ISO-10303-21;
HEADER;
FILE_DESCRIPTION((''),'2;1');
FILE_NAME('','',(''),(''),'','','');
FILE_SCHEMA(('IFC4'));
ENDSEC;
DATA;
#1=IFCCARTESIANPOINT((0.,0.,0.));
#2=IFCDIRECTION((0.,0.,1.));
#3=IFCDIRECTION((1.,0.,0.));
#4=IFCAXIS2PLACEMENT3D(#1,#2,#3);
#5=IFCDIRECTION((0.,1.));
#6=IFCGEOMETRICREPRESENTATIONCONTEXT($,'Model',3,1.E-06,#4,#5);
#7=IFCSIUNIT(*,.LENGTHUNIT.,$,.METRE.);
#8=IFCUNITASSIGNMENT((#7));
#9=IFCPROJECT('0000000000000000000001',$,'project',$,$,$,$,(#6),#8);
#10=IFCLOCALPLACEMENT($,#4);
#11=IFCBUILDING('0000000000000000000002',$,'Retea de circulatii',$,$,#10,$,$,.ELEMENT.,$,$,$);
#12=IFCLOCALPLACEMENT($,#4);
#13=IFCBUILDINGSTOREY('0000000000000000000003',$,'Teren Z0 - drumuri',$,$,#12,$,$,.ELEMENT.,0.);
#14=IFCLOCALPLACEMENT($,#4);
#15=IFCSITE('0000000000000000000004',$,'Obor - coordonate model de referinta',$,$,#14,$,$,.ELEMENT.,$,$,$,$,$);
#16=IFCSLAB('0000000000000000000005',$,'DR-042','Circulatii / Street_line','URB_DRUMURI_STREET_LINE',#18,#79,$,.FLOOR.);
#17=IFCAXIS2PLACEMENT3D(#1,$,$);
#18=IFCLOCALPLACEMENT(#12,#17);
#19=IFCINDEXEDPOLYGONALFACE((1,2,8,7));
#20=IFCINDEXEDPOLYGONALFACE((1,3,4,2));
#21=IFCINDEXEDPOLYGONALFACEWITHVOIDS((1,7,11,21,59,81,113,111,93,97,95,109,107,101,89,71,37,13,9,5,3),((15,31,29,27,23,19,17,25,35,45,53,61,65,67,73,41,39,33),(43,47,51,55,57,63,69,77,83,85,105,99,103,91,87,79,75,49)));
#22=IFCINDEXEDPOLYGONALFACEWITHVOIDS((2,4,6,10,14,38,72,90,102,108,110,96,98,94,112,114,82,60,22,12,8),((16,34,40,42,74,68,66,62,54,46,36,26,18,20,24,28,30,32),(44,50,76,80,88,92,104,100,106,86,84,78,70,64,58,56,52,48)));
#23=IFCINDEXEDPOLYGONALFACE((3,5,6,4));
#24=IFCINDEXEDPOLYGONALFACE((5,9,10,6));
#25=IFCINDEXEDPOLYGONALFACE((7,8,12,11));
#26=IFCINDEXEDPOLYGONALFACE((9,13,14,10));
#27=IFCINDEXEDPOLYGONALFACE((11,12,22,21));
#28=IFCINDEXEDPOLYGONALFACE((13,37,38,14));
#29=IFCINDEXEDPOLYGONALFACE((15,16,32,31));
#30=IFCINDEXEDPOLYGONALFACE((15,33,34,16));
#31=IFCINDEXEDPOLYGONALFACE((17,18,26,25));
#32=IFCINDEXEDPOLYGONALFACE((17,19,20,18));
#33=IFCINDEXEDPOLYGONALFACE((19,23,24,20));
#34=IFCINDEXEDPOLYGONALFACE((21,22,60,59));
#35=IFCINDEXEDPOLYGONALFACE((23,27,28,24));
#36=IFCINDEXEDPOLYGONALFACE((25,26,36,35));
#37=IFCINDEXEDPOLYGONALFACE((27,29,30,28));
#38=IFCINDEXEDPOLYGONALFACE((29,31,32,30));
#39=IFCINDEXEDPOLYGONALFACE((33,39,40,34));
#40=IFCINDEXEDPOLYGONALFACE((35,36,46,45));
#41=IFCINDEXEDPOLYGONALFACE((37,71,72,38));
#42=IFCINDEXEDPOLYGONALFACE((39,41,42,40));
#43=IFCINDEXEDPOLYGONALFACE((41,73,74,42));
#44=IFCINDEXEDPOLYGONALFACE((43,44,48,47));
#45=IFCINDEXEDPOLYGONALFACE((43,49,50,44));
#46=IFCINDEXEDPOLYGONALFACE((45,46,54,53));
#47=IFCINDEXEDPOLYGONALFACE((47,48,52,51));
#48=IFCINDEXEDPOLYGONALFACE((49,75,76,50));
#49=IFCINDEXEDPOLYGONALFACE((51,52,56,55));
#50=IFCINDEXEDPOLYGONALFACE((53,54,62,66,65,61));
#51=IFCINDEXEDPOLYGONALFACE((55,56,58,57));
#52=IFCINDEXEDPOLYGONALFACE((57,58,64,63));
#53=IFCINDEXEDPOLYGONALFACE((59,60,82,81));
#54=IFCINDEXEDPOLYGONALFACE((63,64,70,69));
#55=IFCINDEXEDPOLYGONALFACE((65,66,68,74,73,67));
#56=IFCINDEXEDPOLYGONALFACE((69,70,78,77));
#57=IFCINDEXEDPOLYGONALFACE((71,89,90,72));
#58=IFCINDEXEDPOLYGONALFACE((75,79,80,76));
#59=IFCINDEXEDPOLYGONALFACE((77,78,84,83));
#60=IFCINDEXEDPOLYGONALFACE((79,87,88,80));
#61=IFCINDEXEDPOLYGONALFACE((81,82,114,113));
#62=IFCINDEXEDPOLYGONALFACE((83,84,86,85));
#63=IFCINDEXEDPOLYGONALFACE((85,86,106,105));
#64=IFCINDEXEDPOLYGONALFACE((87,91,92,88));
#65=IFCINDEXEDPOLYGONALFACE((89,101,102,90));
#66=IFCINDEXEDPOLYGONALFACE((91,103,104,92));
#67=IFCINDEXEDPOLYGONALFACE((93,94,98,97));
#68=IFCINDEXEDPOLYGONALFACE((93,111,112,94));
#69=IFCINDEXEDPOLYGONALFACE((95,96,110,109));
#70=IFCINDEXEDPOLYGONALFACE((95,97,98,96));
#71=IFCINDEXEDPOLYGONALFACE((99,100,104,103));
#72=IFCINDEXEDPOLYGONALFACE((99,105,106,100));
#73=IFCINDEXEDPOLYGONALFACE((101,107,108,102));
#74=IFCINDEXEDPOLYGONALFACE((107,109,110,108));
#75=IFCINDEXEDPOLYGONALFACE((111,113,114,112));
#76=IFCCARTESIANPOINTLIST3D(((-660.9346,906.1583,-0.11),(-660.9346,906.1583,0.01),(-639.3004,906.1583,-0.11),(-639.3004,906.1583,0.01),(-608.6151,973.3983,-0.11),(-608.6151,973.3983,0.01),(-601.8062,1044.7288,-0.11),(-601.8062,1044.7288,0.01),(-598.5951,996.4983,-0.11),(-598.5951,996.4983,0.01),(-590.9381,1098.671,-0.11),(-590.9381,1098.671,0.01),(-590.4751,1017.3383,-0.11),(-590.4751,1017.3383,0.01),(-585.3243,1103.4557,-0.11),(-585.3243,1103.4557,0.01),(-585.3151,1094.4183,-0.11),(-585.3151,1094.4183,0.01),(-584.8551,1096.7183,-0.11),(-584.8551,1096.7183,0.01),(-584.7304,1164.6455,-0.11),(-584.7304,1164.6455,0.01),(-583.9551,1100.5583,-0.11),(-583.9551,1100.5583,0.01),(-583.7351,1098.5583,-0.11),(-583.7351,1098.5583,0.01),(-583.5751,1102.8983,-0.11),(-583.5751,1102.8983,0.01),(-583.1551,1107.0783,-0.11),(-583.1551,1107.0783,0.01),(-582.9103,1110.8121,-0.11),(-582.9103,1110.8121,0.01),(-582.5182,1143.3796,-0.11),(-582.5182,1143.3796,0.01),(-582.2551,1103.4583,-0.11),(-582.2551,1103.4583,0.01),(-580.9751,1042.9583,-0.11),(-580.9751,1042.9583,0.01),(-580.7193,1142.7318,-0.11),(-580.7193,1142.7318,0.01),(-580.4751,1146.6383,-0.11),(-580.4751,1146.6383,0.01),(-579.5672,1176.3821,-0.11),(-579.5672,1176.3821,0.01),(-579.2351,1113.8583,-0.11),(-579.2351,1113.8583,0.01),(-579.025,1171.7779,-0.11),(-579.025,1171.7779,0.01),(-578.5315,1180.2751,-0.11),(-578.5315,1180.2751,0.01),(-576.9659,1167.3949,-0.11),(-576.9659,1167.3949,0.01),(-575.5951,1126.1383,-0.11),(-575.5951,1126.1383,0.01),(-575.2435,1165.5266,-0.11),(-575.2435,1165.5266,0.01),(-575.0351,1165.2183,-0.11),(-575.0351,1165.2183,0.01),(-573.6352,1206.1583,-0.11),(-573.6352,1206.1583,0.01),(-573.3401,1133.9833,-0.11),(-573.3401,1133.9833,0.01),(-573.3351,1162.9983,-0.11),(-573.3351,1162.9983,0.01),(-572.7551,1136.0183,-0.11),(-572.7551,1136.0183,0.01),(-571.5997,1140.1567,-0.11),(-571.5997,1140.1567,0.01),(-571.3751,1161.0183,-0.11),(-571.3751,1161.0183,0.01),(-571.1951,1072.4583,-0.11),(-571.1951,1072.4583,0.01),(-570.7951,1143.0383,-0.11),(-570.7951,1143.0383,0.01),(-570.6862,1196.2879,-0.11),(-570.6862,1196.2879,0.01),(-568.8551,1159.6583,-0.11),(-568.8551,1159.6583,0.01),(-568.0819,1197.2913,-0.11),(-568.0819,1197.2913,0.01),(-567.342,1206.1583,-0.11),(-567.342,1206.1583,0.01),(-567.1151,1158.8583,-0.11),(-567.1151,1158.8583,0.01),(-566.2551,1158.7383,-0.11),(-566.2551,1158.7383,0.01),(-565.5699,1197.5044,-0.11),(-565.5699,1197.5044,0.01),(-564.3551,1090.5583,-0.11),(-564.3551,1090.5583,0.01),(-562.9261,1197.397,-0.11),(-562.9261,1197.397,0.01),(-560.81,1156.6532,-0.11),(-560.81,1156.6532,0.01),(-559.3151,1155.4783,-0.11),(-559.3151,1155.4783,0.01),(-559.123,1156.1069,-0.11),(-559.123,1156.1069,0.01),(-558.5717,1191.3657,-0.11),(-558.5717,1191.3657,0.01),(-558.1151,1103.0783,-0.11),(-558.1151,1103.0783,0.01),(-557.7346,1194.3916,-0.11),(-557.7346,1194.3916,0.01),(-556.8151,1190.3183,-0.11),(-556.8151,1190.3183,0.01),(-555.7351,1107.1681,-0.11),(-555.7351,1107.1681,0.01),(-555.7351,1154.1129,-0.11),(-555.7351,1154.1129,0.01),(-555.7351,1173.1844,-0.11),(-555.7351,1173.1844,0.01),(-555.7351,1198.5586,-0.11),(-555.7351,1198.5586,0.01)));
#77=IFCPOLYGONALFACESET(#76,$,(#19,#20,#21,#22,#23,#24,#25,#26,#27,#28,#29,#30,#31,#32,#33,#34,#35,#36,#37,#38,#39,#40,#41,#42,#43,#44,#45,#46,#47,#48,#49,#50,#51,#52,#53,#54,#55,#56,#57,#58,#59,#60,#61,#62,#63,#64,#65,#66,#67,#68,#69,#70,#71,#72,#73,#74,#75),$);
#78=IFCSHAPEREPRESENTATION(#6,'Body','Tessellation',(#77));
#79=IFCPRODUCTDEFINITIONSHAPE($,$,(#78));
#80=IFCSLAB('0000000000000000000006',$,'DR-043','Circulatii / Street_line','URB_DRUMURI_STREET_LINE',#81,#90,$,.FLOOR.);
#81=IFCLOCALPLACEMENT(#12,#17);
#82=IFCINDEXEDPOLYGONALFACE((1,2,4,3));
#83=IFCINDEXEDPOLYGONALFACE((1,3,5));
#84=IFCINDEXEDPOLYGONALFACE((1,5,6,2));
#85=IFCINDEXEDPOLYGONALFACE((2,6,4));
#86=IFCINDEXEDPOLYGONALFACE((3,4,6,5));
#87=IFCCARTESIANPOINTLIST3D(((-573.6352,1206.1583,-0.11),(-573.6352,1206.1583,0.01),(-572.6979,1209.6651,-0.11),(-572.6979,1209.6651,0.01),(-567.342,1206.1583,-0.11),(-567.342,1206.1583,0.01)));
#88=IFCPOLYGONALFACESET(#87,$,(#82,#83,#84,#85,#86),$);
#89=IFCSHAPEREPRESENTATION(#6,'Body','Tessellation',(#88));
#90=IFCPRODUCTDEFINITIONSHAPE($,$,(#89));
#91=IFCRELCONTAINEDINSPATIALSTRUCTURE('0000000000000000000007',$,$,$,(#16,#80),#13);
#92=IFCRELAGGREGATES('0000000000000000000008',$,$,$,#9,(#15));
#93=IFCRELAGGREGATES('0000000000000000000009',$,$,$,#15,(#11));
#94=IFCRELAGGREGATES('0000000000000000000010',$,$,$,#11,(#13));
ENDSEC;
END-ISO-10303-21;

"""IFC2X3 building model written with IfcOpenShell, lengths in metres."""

from ifc_helpers import new_model, si_unit, direction, frame, origin_with_axes, place, context, project, spatial, polyline, outline, extrude, element, save


model = new_model("IFC2X3")

# Units and contexts
model_context = context("Model", 3, precision=1e-06, world=origin_with_axes(), true_north=direction((0.0, 1.0)))
ifc_project = project(units=[si_unit("LENGTHUNIT", "METRE")], contexts=[model_context])

# Site, building, storey
site_placement = place(None, origin_with_axes())
site = spatial("IfcSite", under=ifc_project, at=site_placement, Name="Obor - coordonate model de referinta", CompositionType="ELEMENT")
building_placement = place(None, origin_with_axes())
building = spatial("IfcBuilding", under=site, at=building_placement, Name="Retea de circulatii", CompositionType="ELEMENT")
storey_placement = place(None, origin_with_axes())
storey = spatial("IfcBuildingStorey", under=building, at=storey_placement, Name="Teren Z0 - drumuri", CompositionType="ELEMENT", Elevation=0.0)

# Slabs
slab_1_placement = place(None, origin_with_axes())
element("IfcSlab", 1, at=slab_1_placement, inside=storey, Name="DR-042", Description="Circulatii / Street_line", ObjectType="URB_DRUMURI_STREET_LINE", PredefinedType="FLOOR", context=model_context, shape_type="SweptSolid", body=[
    extrude(outline(polyline([(-584.7304, 1164.6455), (-590.9381, 1098.671), (-601.8062, 1044.7288), (-660.9346, 906.1583), (-639.3004, 906.1583), (-608.6151, 973.3983), (-598.5951, 996.4983), (-590.4751, 1017.3383), (-580.9751, 1042.9583), (-571.1951, 1072.4583), (-564.3551, 1090.5583), (-558.1151, 1103.0783), (-555.7351, 1107.1681), (-555.7351, 1154.1129), (-559.3151, 1155.4783), (-559.123, 1156.1069), (-560.81, 1156.6532), (-555.7351, 1173.1844), (-555.7351, 1198.5586), (-567.342, 1206.1583), (-573.6352, 1206.1583), (-584.7304, 1164.6455)]), holes=[polyline([(-571.5997, 1140.1567), (-572.7551, 1136.0183), (-573.3401, 1133.9833), (-575.5951, 1126.1383), (-579.2351, 1113.8583), (-582.2551, 1103.4583), (-583.7351, 1098.5583), (-585.3151, 1094.4183), (-584.8551, 1096.7183), (-583.9551, 1100.5583), (-583.5751, 1102.8983), (-583.1551, 1107.0783), (-582.9103, 1110.8121), (-585.3243, 1103.4557), (-582.5182, 1143.3796), (-580.7193, 1142.7318), (-580.4751, 1146.6383), (-570.7951, 1143.0383), (-571.5997, 1140.1567)]), polyline([(-570.6862, 1196.2879), (-568.0819, 1197.2913), (-565.5699, 1197.5044), (-562.9261, 1197.397), (-557.7346, 1194.3916), (-558.5717, 1191.3657), (-556.8151, 1190.3183), (-566.2551, 1158.7383), (-567.1151, 1158.8583), (-568.8551, 1159.6583), (-571.3751, 1161.0183), (-573.3351, 1162.9983), (-575.0351, 1165.2183), (-575.2435, 1165.5266), (-576.9659, 1167.3949), (-579.025, 1171.7779), (-579.5672, 1176.3821), (-578.5315, 1180.2751), (-570.6862, 1196.2879)])]), frame((0.0, 0.0, -0.11), z_axis=(0.0, 0.0, 1.0), x_axis=(1.0, 0.0, 0.0)), (0.0, 0.0, 1.0), 0.12),
])
slab_2_placement = place(None, origin_with_axes())
element("IfcSlab", 2, at=slab_2_placement, inside=storey, Name="DR-043", Description="Circulatii / Street_line", ObjectType="URB_DRUMURI_STREET_LINE", PredefinedType="FLOOR", context=model_context, shape_type="SweptSolid", body=[
    extrude(outline(polyline([(-572.6979, 1209.6651), (-573.6352, 1206.1583), (-567.342, 1206.1583), (-572.6979, 1209.6651)])), frame((0.0, 0.0, -0.11), z_axis=(0.0, 0.0, 1.0), x_axis=(1.0, 0.0, 0.0)), (0.0, 0.0, 1.0), 0.12),
])

save(model, "model.ifc")
